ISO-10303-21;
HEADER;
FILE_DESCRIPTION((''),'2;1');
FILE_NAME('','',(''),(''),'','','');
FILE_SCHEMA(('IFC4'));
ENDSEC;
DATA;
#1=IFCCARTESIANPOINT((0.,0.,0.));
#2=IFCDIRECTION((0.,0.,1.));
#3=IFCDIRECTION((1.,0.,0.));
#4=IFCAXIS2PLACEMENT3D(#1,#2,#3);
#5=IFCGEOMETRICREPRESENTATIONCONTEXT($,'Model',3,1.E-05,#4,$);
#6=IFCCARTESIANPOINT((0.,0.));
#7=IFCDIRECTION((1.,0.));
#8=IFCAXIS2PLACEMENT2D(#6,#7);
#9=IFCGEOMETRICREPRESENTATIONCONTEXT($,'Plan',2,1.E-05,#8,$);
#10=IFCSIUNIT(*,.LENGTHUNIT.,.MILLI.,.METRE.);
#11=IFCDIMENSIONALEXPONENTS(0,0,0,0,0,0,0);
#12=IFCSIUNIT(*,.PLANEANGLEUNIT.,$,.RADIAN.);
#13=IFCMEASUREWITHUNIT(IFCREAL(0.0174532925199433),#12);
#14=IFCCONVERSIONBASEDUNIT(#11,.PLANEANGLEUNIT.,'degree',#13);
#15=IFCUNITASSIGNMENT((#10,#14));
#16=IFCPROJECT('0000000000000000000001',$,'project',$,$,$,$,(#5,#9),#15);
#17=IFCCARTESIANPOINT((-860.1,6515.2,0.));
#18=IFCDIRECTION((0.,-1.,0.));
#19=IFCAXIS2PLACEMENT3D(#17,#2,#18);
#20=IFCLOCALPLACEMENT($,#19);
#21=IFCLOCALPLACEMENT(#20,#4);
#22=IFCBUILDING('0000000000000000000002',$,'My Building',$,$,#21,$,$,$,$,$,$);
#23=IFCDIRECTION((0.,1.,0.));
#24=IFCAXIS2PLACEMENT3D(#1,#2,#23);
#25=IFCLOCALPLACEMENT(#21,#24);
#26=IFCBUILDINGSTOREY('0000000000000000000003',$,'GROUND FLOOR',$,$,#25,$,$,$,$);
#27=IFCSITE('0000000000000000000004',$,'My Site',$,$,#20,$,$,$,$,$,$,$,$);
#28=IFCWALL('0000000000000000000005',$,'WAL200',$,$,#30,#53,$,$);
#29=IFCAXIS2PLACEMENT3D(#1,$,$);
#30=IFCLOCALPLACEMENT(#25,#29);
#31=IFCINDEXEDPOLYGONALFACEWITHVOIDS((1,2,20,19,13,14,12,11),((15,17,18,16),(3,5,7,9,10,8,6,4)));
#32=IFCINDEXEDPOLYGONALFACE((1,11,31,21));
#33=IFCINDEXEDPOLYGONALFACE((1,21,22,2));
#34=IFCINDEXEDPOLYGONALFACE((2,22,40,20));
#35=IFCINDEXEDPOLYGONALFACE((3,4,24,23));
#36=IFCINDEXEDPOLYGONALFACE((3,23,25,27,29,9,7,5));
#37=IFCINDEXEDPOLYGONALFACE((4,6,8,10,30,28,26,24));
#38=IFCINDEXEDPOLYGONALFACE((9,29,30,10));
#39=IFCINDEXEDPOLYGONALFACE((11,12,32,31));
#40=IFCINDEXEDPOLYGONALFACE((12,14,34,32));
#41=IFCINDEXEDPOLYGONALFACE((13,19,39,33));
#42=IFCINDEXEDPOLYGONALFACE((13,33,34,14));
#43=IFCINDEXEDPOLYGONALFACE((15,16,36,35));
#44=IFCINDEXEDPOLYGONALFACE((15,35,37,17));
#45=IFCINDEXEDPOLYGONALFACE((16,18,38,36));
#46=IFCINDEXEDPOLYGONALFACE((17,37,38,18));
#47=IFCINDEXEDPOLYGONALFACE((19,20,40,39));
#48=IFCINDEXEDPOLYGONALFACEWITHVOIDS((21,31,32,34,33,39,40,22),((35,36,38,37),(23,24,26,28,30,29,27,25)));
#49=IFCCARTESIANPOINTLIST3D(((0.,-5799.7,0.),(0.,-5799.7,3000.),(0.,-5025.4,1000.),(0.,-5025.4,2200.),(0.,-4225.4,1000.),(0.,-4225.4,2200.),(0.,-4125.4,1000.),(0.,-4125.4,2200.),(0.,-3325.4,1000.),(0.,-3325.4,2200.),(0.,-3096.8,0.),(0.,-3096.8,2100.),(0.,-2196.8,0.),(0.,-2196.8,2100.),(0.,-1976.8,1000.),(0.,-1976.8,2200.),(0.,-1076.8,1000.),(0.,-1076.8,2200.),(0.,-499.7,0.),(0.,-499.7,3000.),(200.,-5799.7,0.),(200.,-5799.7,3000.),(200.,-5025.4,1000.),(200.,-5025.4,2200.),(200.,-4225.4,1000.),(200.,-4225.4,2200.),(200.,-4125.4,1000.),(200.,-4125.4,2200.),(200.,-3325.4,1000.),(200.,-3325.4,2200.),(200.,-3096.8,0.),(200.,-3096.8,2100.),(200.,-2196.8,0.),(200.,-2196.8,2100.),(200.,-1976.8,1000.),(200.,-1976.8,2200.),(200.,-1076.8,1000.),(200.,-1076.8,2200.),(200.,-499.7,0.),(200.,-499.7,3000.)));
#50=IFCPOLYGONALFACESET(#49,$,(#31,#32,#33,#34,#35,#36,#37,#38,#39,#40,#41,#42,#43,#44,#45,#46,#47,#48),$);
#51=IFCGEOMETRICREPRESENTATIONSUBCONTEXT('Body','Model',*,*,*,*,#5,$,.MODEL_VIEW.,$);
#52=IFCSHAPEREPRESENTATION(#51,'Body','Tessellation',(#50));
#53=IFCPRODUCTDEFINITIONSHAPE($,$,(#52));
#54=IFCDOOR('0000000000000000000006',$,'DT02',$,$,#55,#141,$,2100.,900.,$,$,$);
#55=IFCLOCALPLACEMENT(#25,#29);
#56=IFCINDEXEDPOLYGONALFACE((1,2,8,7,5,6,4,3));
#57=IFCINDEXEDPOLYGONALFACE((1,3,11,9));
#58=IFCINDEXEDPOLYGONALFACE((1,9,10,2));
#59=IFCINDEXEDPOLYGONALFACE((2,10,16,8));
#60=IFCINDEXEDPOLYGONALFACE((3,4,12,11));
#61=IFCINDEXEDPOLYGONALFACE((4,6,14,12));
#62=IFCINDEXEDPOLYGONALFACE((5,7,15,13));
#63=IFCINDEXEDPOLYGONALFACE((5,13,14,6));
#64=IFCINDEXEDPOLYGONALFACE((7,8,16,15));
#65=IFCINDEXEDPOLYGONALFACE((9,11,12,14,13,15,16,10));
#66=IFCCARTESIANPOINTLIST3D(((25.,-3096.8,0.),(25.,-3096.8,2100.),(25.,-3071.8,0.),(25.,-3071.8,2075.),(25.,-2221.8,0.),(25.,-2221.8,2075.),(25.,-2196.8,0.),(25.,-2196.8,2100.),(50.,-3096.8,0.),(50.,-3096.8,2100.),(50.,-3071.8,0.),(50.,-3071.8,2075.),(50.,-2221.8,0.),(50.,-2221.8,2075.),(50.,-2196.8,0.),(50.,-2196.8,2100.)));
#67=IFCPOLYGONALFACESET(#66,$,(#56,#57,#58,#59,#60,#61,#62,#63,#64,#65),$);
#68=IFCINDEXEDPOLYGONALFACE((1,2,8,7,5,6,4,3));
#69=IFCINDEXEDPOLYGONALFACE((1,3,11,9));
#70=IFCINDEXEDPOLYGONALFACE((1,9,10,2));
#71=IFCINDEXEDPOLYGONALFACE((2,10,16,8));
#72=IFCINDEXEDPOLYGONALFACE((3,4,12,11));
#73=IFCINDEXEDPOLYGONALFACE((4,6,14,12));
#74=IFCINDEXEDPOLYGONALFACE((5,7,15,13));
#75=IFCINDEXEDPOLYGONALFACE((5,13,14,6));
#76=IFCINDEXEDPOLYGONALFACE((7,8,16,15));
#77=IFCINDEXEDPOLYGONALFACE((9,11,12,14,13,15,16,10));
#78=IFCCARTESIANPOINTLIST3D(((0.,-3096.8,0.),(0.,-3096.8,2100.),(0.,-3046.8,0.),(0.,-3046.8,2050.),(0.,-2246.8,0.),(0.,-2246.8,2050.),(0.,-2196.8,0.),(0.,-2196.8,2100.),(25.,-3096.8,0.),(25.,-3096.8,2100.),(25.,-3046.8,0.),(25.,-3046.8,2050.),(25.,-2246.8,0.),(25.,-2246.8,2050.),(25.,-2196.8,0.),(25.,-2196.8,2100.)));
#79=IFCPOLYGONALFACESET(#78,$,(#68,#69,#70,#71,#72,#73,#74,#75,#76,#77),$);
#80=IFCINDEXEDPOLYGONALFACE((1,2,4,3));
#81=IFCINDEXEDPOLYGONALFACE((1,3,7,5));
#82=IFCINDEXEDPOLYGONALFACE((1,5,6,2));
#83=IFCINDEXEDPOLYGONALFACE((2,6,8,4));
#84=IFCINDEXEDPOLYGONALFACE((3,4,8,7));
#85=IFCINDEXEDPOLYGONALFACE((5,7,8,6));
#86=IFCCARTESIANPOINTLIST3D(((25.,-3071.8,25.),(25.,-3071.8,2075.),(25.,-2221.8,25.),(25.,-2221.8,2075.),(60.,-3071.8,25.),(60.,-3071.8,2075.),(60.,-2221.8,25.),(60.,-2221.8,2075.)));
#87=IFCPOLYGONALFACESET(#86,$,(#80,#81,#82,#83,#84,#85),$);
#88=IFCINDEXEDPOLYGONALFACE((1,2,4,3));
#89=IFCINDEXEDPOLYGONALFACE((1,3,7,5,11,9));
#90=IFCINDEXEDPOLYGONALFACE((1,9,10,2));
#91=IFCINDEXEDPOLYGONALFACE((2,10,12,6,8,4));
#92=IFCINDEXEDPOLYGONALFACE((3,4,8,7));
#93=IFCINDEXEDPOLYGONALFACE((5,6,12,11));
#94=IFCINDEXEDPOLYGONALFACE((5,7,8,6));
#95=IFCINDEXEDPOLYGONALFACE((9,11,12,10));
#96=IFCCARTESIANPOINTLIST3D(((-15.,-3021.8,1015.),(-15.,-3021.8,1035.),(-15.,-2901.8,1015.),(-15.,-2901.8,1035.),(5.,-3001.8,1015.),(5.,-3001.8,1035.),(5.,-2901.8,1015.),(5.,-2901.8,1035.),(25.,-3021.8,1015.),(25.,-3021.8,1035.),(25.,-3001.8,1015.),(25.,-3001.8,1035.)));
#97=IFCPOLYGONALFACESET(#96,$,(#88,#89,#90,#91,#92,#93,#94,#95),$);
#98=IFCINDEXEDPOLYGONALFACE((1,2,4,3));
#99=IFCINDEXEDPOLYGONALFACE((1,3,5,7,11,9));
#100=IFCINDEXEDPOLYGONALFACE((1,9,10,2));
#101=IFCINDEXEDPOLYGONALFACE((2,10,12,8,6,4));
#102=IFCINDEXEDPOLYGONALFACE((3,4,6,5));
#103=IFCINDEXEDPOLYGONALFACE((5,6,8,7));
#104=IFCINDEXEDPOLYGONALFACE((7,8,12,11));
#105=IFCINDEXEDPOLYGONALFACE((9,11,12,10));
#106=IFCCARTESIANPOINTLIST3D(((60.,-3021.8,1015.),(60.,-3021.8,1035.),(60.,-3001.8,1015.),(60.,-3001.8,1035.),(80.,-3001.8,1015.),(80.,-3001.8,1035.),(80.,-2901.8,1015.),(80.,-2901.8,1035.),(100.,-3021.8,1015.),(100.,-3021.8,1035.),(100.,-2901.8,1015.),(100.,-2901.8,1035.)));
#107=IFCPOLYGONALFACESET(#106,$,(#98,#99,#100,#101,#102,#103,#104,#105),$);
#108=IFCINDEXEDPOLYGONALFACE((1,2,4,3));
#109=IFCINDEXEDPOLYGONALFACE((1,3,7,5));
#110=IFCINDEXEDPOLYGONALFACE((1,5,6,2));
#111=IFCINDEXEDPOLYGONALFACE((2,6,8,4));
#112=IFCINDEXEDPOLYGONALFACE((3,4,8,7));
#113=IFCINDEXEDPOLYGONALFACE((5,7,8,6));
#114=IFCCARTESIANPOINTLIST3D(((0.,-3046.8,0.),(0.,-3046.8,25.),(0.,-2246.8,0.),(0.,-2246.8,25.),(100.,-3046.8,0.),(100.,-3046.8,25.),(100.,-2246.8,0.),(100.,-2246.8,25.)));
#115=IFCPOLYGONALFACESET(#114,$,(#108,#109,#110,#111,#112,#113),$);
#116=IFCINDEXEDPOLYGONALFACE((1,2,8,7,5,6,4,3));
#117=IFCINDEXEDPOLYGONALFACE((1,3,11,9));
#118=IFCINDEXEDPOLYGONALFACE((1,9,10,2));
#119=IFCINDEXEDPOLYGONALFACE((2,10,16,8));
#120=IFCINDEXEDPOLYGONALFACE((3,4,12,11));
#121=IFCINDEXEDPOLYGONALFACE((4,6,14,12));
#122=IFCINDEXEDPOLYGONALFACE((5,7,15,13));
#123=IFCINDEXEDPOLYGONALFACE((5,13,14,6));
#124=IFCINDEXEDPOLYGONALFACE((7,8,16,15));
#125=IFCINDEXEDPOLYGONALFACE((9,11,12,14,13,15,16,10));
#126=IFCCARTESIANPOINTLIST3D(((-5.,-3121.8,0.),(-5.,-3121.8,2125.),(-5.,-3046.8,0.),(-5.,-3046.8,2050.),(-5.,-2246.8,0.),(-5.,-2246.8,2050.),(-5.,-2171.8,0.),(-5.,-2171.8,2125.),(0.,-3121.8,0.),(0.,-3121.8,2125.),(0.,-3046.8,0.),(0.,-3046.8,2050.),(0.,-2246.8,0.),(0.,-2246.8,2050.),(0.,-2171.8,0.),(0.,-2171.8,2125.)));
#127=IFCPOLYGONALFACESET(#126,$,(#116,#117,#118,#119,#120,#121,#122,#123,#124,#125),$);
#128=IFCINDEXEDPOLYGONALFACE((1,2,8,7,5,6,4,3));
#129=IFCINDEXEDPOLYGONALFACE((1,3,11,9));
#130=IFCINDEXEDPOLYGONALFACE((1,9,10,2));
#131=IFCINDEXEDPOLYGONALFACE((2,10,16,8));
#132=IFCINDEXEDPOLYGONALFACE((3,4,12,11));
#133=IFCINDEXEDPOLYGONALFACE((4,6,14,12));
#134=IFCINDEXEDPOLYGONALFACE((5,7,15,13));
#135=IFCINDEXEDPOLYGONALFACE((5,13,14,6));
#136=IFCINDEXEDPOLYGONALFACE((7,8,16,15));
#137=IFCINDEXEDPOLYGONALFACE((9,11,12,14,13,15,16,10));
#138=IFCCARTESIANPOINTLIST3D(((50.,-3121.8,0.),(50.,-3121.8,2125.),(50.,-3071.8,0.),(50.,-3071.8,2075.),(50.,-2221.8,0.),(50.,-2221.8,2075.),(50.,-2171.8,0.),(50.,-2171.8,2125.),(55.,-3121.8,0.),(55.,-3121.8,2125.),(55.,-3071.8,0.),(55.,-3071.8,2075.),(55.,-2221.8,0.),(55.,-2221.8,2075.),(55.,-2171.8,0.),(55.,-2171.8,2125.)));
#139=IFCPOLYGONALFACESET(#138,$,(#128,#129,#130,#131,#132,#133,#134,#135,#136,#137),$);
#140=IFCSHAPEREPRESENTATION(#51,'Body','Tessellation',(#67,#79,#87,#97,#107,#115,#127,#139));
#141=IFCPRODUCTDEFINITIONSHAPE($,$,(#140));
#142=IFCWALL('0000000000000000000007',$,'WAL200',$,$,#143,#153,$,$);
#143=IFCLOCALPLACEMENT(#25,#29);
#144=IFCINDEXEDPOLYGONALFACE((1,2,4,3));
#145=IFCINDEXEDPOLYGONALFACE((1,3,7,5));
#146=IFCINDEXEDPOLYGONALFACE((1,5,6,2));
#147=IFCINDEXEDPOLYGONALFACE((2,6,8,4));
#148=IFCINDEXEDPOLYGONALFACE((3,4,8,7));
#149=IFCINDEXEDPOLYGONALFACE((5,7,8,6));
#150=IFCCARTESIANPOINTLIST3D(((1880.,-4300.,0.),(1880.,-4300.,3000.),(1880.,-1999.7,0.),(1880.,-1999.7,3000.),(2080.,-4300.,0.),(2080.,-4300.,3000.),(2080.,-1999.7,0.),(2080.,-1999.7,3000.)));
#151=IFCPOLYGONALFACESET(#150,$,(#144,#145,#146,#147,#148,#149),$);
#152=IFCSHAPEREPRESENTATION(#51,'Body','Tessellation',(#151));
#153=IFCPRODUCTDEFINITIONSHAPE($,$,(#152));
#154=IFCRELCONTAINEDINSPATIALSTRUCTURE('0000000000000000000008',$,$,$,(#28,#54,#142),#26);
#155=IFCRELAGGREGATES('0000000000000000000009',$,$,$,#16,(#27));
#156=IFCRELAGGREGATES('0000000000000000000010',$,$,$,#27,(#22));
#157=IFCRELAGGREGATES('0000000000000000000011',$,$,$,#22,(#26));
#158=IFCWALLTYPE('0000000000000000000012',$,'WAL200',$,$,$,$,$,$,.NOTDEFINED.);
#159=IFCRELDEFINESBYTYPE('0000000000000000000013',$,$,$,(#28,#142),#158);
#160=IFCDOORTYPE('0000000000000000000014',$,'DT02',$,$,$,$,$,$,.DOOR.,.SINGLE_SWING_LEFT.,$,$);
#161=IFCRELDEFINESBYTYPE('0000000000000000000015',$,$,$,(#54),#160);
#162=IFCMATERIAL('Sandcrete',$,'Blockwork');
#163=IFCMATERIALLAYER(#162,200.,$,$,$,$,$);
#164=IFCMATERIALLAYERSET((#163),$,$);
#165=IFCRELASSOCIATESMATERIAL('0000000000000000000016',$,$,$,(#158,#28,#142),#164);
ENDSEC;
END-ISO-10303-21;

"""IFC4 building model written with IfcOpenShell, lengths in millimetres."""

from ifc_helpers import new_model, entity, si_unit, converted_unit, frame, origin_with_axes, origin_2d_with_axis, place, context, subcontext, project, spatial, line, indexed_curve, outline, extrude, shape, source, transform, mapped, material, layer, layer_set, layer_usage, type_object, type_shapes, element, fill, save


model = new_model("IFC4")

# Units and contexts
model_context = context("Model", 3, precision=1e-05, world=origin_with_axes())
plan_context = context("Plan", 2, precision=1e-05, world=origin_2d_with_axis())
body_context_1 = subcontext(model_context, "Body", "Model", "MODEL_VIEW")
body_context_2 = subcontext(plan_context, "Body", "Plan", "PLAN_VIEW")
ifc_project = project(units=[si_unit("LENGTHUNIT", "METRE", prefix="MILLI"), converted_unit("PLANEANGLEUNIT", "degree", entity("IfcReal", 0.0174532925199433), si_unit("PLANEANGLEUNIT", "RADIAN"), dimensions=[0, 0, 0, 0, 0, 0, 0])], contexts=[model_context, plan_context])

# Site, building, storey
site_placement = place(None, frame((-860.1, 6515.2, 0.0), z_axis=(0.0, 0.0, 1.0), x_axis=(0.0, -1.0, 0.0)))
site = spatial("IfcSite", under=ifc_project, at=site_placement, Name="My Site")
building_placement = place(site_placement, frame((0.0, 0.0, 0.0), z_axis=(0.0, 0.0, 1.0), x_axis=(1.0, 0.0, 0.0)))
building = spatial("IfcBuilding", under=site, at=building_placement, Name="My Building")
storey_placement = place(building_placement, frame((0.0, 0.0, 0.0), z_axis=(0.0, 0.0, 1.0), x_axis=(0.0, 1.0, 0.0)))
storey = spatial("IfcBuildingStorey", under=building, at=storey_placement, Name="GROUND FLOOR")

# Shared definitions
ifc_material_1 = material(Name="Sandcrete", Category="Blockwork")
ifc_layer_1 = layer(ifc_material_1, 200.0)
ifc_layer_set_1 = layer_set([ifc_layer_1])
wall_type_1 = type_object("IfcWallType", Name="WAL200", PredefinedType="NOTDEFINED", material=ifc_layer_set_1)

# Wall, openings, door
ifc_layer_usage_1 = layer_usage(ifc_layer_set_1, "AXIS2", "POSITIVE", 0.0)
wall_1_placement = place(storey_placement, frame((0.0, -499.7, 0.0), z_axis=(0.0, 0.0, 1.0), x_axis=(-0.000001, -1.0, 0.0)))
wall_1 = element("IfcWall", 1, at=wall_1_placement, inside=storey, type_object=wall_type_1, material=ifc_layer_usage_1, Name="WAL200", context=body_context_1, shape_type="SweptSolid", body=[
    extrude(outline(indexed_curve([(0.0, 0.0), (0.0, 200.0), (5300.0, 200.0), (5300.0, 0.0), (0.0, 0.0)], self_intersect=False)), origin_with_axes(), (0.0, 0.0, 1.0), 3000.0),
])
shared_shape_1 = source(origin_with_axes(), body_context_1, "Body", "SweptSolid", [
    extrude(outline(indexed_curve([(0.0, 0.0), (900.0, 0.0), (900.0, 2100.0), (0.0, 2100.0)], segments=[line(1, 2), line(2, 3), line(3, 4), line(4, 1)])), frame((0.0, -100.0, 0.0), z_axis=(0.0, -1.0, 0.0), x_axis=(1.0, 0.0, 0.0)), (0.0, 0.0, -1.0), 400.0),
])
opening_1_placement = place(wall_1_placement, frame((1697.1, 0.0, 0.0), z_axis=(0.0, 0.0, 1.0), x_axis=(1.0, 0.0, 0.0)))
opening_1 = element("IfcOpeningElement", 2, at=opening_1_placement, cuts=wall_1, PredefinedType="OPENING", context=body_context_1, shape_type="MappedRepresentation", body=[
    mapped(shared_shape_1, transform((0.0, 0.0, 0.0), x_axis=(1.0, 0.0, 0.0), y_axis=(0.0, 1.0, 0.0), z_axis=(0.0, 0.0, 1.0), scale=1.0)),
])
shared_shape_2 = source(origin_with_axes(), body_context_1, "Body", "SweptSolid", [
    extrude(outline(indexed_curve([(0.0, 0.0), (900.0, 0.0), (900.0, 1200.0), (0.0, 1200.0)], segments=[line(1, 2), line(2, 3), line(3, 4), line(4, 1)])), frame((0.0, -100.0, 0.0), z_axis=(0.0, -1.0, 0.0), x_axis=(1.0, 0.0, 0.0)), (0.0, 0.0, -1.0), 400.0),
])
opening_2_placement = place(wall_1_placement, frame((577.1, 68.2, 1000.0), z_axis=(0.0, 0.0, 1.0), x_axis=(1.0, 0.0, 0.0)))
element("IfcOpeningElement", 3, at=opening_2_placement, cuts=wall_1, PredefinedType="OPENING", context=body_context_1, shape_type="MappedRepresentation", body=[
    mapped(shared_shape_2, transform((0.0, 0.0, 0.0), x_axis=(1.0, 0.0, 0.0), y_axis=(0.0, 1.0, 0.0), z_axis=(0.0, 0.0, 1.0), scale=1.0)),
])
opening_3_placement = place(wall_1_placement, frame((2825.8, 50.0, 1000.0), z_axis=(0.0, 0.0, 1.0), x_axis=(1.0, 0.0, 0.0)))
element("IfcOpeningElement", 4, at=opening_3_placement, cuts=wall_1, PredefinedType="OPENING", context=body_context_1, shape_type="MappedRepresentation", body=[
    mapped(shared_shape_2, transform((0.0, 0.0, 0.0), x_axis=(1.0, 0.0, 0.0), y_axis=(0.0, 1.0, 0.0), z_axis=(0.0, 0.0, 1.0), scale=1.0)),
])
opening_4_placement = place(wall_1_placement, frame((3625.8, 50.0, 1000.0), z_axis=(0.0, 0.0, 1.0), x_axis=(1.0, 0.0, 0.0)))
element("IfcOpeningElement", 5, at=opening_4_placement, cuts=wall_1, PredefinedType="OPENING", context=body_context_1, shape_type="MappedRepresentation", body=[
    mapped(shared_shape_2, transform((0.0, 0.0, 0.0), x_axis=(1.0, 0.0, 0.0), y_axis=(0.0, 1.0, 0.0), z_axis=(0.0, 0.0, 1.0), scale=1.0)),
])
door_type = type_object("IfcDoorType", Name="DT02", OperationType="SINGLE_SWING_LEFT", PredefinedType="DOOR")
shared_shape_3 = source(origin_with_axes(), body_context_1, "Body", "SweptSolid", [
    extrude(outline(indexed_curve([(0.0, 0.0), (0.0, 2100.0), (900.0, 2100.0), (900.0, 0.0), (875.0, 0.0), (875.0, 2075.0), (25.0, 2075.0), (25.0, 0.0)], segments=[line(1, 2), line(2, 3), line(3, 4), line(4, 5), line(5, 6), line(6, 7), line(7, 8), line(8, 1)])), frame((0.0, 25.0, 0.0), z_axis=(0.0, -1.0, 0.0), x_axis=(1.0, 0.0, 0.0)), (0.0, 0.0, -1.0), 25.0),
    extrude(outline(indexed_curve([(0.0, 0.0), (0.0, 2100.0), (900.0, 2100.0), (900.0, 0.0), (850.0, 0.0), (850.0, 2050.0), (50.0, 2050.0), (50.0, 0.0)], segments=[line(1, 2), line(2, 3), line(3, 4), line(4, 5), line(5, 6), line(6, 7), line(7, 8), line(8, 1)])), frame((0.0, 0.0, 0.0), z_axis=(0.0, -1.0, 0.0), x_axis=(1.0, 0.0, 0.0)), (0.0, 0.0, -1.0), 25.0),
    extrude(outline(indexed_curve([(0.0, 0.0), (850.0, 0.0), (850.0, 35.0), (0.0, 35.0)], segments=[line(1, 2), line(2, 3), line(3, 4), line(4, 1)])), frame((25.0, 25.0, 25.0), z_axis=(0.0, 0.0, 1.0), x_axis=(1.0, 0.0, 0.0)), (0.0, 0.0, 1.0), 2050.0),
    extrude(outline(indexed_curve([(0.0, 0.0), (0.0, -40.0), (-120.0, -40.0), (-120.0, -20.0), (-20.0, -20.0), (-20.0, 0.0)], segments=[line(1, 2), line(2, 3), line(3, 4), line(4, 5), line(5, 6), line(6, 1)])), frame((825.0, 25.0, 1015.0), z_axis=(0.0, 0.0, 1.0), x_axis=(1.0, 0.0, 0.0)), (0.0, 0.0, 1.0), 20.0),
    extrude(outline(indexed_curve([(0.0, 0.0), (0.0, 40.0), (-120.0, 40.0), (-120.0, 20.0), (-20.0, 20.0), (-20.0, 0.0)], segments=[line(1, 2), line(2, 3), line(3, 4), line(4, 5), line(5, 6), line(6, 1)])), frame((825.0, 60.0, 1015.0), z_axis=(0.0, 0.0, 1.0), x_axis=(1.0, 0.0, 0.0)), (0.0, 0.0, 1.0), 20.0),
    extrude(outline(indexed_curve([(0.0, 0.0), (800.0, 0.0), (800.0, 100.0), (0.0, 100.0)], segments=[line(1, 2), line(2, 3), line(3, 4), line(4, 1)])), frame((50.0, 0.0, 0.0), z_axis=(0.0, 0.0, 1.0), x_axis=(1.0, 0.0, 0.0)), (0.0, 0.0, 1.0), 25.0),
    extrude(outline(indexed_curve([(0.0, 0.0), (0.0, 2125.0), (950.0, 2125.0), (950.0, 0.0), (875.0, 0.0), (875.0, 2050.0), (75.0, 2050.0), (75.0, 0.0)], segments=[line(1, 2), line(2, 3), line(3, 4), line(4, 5), line(5, 6), line(6, 7), line(7, 8), line(8, 1)])), frame((-25.0, -5.0, 0.0), z_axis=(0.0, -1.0, 0.0), x_axis=(1.0, 0.0, 0.0)), (0.0, 0.0, -1.0), 5.0),
    extrude(outline(indexed_curve([(0.0, 0.0), (0.0, 2125.0), (950.0, 2125.0), (950.0, 0.0), (900.0, 0.0), (900.0, 2075.0), (50.0, 2075.0), (50.0, 0.0)], segments=[line(1, 2), line(2, 3), line(3, 4), line(4, 5), line(5, 6), line(6, 7), line(7, 8), line(8, 1)])), frame((-25.0, 50.0, 0.0), z_axis=(0.0, -1.0, 0.0), x_axis=(1.0, 0.0, 0.0)), (0.0, 0.0, -1.0), 5.0),
])
shared_shape_4 = source(origin_with_axes(), body_context_2, "Body", "Curve2D", [
    entity("IfcIndexedPolyCurve", entity("IfcCartesianPointList2D", [[0.0, 0.0], [0.0, 50.0], [25.0, 50.0], [25.0, 25.0], [50.0, 25.0], [50.0, 0.0]]), [entity("IfcLineIndex", [1, 2]), entity("IfcLineIndex", [2, 3]), entity("IfcLineIndex", [3, 4]), entity("IfcLineIndex", [4, 5]), entity("IfcLineIndex", [5, 6]), entity("IfcLineIndex", [6, 1])]),
    entity("IfcIndexedPolyCurve", entity("IfcCartesianPointList2D", [[900.0, 0.0], [900.0, 50.0], [875.0, 50.0], [875.0, 25.0], [850.0, 25.0], [850.0, 0.0]]), [entity("IfcLineIndex", [1, 2]), entity("IfcLineIndex", [2, 3]), entity("IfcLineIndex", [3, 4]), entity("IfcLineIndex", [4, 5]), entity("IfcLineIndex", [5, 6]), entity("IfcLineIndex", [6, 1])]),
    entity("IfcTrimmedCurve", entity("IfcEllipse", entity("IfcAxis2Placement2D", entity("IfcCartesianPoint", [60.0, 50.0]), entity("IfcDirection", [1.0, 0.0])), 815.0, 850.0), [entity("IfcCartesianPoint", [875.0, 50.0])], [entity("IfcCartesianPoint", [60.0, 900.0])], True, "CARTESIAN"),
    entity("IfcIndexedPolyCurve", entity("IfcCartesianPointList2D", [[25.0, 50.0], [60.0, 50.0], [60.0, 900.0], [25.0, 900.0]]), [entity("IfcLineIndex", [1, 2]), entity("IfcLineIndex", [2, 3]), entity("IfcLineIndex", [3, 4]), entity("IfcLineIndex", [4, 1])]),
])
type_shapes(door_type, [shared_shape_3, shared_shape_4])
door_placement = place(opening_1_placement, frame((0.0, 0.0, 0.0), z_axis=(0.0, 0.0, 1.0), x_axis=(1.0, 0.0, 0.0)))
door = element("IfcDoor", 6, at=door_placement, inside=storey, type_object=door_type, Name="DT02", OverallHeight=2100.0, OverallWidth=900.0, shapes=[
    shape(body_context_1, "Body", "MappedRepresentation", [mapped(shared_shape_3, transform((0.0, 0.0, 0.0), x_axis=(1.0, 0.0, 0.0), y_axis=(0.0, 1.0, 0.0), z_axis=(0.0, 0.0, 1.0), scale=1.0))]),
    shape(body_context_2, "Body", "MappedRepresentation", [mapped(shared_shape_4, transform((0.0, 0.0, 0.0), x_axis=(1.0, 0.0, 0.0), y_axis=(0.0, 1.0, 0.0), z_axis=(0.0, 0.0, 1.0), scale=1.0))]),
])
fill(opening_1, door)

# Wall
ifc_layer_usage_2 = layer_usage(ifc_layer_set_1, "AXIS2", "POSITIVE", 0.0)
wall_2_placement = place(storey_placement, frame((1880.0, -1999.7, 0.0), z_axis=(0.0, 0.0, 1.0), x_axis=(0.0, -1.0, 0.0)))
element("IfcWall", 7, at=wall_2_placement, inside=storey, type_object=wall_type_1, material=ifc_layer_usage_2, Name="WAL200", context=body_context_1, shape_type="SweptSolid", body=[
    extrude(outline(indexed_curve([(0.0, 0.0), (0.0, 200.0), (2300.3, 200.0), (2300.3, 0.0), (0.0, 0.0)], self_intersect=False)), origin_with_axes(), (0.0, 0.0, 1.0), 3000.0),
])

save(model, "model.ifc")
